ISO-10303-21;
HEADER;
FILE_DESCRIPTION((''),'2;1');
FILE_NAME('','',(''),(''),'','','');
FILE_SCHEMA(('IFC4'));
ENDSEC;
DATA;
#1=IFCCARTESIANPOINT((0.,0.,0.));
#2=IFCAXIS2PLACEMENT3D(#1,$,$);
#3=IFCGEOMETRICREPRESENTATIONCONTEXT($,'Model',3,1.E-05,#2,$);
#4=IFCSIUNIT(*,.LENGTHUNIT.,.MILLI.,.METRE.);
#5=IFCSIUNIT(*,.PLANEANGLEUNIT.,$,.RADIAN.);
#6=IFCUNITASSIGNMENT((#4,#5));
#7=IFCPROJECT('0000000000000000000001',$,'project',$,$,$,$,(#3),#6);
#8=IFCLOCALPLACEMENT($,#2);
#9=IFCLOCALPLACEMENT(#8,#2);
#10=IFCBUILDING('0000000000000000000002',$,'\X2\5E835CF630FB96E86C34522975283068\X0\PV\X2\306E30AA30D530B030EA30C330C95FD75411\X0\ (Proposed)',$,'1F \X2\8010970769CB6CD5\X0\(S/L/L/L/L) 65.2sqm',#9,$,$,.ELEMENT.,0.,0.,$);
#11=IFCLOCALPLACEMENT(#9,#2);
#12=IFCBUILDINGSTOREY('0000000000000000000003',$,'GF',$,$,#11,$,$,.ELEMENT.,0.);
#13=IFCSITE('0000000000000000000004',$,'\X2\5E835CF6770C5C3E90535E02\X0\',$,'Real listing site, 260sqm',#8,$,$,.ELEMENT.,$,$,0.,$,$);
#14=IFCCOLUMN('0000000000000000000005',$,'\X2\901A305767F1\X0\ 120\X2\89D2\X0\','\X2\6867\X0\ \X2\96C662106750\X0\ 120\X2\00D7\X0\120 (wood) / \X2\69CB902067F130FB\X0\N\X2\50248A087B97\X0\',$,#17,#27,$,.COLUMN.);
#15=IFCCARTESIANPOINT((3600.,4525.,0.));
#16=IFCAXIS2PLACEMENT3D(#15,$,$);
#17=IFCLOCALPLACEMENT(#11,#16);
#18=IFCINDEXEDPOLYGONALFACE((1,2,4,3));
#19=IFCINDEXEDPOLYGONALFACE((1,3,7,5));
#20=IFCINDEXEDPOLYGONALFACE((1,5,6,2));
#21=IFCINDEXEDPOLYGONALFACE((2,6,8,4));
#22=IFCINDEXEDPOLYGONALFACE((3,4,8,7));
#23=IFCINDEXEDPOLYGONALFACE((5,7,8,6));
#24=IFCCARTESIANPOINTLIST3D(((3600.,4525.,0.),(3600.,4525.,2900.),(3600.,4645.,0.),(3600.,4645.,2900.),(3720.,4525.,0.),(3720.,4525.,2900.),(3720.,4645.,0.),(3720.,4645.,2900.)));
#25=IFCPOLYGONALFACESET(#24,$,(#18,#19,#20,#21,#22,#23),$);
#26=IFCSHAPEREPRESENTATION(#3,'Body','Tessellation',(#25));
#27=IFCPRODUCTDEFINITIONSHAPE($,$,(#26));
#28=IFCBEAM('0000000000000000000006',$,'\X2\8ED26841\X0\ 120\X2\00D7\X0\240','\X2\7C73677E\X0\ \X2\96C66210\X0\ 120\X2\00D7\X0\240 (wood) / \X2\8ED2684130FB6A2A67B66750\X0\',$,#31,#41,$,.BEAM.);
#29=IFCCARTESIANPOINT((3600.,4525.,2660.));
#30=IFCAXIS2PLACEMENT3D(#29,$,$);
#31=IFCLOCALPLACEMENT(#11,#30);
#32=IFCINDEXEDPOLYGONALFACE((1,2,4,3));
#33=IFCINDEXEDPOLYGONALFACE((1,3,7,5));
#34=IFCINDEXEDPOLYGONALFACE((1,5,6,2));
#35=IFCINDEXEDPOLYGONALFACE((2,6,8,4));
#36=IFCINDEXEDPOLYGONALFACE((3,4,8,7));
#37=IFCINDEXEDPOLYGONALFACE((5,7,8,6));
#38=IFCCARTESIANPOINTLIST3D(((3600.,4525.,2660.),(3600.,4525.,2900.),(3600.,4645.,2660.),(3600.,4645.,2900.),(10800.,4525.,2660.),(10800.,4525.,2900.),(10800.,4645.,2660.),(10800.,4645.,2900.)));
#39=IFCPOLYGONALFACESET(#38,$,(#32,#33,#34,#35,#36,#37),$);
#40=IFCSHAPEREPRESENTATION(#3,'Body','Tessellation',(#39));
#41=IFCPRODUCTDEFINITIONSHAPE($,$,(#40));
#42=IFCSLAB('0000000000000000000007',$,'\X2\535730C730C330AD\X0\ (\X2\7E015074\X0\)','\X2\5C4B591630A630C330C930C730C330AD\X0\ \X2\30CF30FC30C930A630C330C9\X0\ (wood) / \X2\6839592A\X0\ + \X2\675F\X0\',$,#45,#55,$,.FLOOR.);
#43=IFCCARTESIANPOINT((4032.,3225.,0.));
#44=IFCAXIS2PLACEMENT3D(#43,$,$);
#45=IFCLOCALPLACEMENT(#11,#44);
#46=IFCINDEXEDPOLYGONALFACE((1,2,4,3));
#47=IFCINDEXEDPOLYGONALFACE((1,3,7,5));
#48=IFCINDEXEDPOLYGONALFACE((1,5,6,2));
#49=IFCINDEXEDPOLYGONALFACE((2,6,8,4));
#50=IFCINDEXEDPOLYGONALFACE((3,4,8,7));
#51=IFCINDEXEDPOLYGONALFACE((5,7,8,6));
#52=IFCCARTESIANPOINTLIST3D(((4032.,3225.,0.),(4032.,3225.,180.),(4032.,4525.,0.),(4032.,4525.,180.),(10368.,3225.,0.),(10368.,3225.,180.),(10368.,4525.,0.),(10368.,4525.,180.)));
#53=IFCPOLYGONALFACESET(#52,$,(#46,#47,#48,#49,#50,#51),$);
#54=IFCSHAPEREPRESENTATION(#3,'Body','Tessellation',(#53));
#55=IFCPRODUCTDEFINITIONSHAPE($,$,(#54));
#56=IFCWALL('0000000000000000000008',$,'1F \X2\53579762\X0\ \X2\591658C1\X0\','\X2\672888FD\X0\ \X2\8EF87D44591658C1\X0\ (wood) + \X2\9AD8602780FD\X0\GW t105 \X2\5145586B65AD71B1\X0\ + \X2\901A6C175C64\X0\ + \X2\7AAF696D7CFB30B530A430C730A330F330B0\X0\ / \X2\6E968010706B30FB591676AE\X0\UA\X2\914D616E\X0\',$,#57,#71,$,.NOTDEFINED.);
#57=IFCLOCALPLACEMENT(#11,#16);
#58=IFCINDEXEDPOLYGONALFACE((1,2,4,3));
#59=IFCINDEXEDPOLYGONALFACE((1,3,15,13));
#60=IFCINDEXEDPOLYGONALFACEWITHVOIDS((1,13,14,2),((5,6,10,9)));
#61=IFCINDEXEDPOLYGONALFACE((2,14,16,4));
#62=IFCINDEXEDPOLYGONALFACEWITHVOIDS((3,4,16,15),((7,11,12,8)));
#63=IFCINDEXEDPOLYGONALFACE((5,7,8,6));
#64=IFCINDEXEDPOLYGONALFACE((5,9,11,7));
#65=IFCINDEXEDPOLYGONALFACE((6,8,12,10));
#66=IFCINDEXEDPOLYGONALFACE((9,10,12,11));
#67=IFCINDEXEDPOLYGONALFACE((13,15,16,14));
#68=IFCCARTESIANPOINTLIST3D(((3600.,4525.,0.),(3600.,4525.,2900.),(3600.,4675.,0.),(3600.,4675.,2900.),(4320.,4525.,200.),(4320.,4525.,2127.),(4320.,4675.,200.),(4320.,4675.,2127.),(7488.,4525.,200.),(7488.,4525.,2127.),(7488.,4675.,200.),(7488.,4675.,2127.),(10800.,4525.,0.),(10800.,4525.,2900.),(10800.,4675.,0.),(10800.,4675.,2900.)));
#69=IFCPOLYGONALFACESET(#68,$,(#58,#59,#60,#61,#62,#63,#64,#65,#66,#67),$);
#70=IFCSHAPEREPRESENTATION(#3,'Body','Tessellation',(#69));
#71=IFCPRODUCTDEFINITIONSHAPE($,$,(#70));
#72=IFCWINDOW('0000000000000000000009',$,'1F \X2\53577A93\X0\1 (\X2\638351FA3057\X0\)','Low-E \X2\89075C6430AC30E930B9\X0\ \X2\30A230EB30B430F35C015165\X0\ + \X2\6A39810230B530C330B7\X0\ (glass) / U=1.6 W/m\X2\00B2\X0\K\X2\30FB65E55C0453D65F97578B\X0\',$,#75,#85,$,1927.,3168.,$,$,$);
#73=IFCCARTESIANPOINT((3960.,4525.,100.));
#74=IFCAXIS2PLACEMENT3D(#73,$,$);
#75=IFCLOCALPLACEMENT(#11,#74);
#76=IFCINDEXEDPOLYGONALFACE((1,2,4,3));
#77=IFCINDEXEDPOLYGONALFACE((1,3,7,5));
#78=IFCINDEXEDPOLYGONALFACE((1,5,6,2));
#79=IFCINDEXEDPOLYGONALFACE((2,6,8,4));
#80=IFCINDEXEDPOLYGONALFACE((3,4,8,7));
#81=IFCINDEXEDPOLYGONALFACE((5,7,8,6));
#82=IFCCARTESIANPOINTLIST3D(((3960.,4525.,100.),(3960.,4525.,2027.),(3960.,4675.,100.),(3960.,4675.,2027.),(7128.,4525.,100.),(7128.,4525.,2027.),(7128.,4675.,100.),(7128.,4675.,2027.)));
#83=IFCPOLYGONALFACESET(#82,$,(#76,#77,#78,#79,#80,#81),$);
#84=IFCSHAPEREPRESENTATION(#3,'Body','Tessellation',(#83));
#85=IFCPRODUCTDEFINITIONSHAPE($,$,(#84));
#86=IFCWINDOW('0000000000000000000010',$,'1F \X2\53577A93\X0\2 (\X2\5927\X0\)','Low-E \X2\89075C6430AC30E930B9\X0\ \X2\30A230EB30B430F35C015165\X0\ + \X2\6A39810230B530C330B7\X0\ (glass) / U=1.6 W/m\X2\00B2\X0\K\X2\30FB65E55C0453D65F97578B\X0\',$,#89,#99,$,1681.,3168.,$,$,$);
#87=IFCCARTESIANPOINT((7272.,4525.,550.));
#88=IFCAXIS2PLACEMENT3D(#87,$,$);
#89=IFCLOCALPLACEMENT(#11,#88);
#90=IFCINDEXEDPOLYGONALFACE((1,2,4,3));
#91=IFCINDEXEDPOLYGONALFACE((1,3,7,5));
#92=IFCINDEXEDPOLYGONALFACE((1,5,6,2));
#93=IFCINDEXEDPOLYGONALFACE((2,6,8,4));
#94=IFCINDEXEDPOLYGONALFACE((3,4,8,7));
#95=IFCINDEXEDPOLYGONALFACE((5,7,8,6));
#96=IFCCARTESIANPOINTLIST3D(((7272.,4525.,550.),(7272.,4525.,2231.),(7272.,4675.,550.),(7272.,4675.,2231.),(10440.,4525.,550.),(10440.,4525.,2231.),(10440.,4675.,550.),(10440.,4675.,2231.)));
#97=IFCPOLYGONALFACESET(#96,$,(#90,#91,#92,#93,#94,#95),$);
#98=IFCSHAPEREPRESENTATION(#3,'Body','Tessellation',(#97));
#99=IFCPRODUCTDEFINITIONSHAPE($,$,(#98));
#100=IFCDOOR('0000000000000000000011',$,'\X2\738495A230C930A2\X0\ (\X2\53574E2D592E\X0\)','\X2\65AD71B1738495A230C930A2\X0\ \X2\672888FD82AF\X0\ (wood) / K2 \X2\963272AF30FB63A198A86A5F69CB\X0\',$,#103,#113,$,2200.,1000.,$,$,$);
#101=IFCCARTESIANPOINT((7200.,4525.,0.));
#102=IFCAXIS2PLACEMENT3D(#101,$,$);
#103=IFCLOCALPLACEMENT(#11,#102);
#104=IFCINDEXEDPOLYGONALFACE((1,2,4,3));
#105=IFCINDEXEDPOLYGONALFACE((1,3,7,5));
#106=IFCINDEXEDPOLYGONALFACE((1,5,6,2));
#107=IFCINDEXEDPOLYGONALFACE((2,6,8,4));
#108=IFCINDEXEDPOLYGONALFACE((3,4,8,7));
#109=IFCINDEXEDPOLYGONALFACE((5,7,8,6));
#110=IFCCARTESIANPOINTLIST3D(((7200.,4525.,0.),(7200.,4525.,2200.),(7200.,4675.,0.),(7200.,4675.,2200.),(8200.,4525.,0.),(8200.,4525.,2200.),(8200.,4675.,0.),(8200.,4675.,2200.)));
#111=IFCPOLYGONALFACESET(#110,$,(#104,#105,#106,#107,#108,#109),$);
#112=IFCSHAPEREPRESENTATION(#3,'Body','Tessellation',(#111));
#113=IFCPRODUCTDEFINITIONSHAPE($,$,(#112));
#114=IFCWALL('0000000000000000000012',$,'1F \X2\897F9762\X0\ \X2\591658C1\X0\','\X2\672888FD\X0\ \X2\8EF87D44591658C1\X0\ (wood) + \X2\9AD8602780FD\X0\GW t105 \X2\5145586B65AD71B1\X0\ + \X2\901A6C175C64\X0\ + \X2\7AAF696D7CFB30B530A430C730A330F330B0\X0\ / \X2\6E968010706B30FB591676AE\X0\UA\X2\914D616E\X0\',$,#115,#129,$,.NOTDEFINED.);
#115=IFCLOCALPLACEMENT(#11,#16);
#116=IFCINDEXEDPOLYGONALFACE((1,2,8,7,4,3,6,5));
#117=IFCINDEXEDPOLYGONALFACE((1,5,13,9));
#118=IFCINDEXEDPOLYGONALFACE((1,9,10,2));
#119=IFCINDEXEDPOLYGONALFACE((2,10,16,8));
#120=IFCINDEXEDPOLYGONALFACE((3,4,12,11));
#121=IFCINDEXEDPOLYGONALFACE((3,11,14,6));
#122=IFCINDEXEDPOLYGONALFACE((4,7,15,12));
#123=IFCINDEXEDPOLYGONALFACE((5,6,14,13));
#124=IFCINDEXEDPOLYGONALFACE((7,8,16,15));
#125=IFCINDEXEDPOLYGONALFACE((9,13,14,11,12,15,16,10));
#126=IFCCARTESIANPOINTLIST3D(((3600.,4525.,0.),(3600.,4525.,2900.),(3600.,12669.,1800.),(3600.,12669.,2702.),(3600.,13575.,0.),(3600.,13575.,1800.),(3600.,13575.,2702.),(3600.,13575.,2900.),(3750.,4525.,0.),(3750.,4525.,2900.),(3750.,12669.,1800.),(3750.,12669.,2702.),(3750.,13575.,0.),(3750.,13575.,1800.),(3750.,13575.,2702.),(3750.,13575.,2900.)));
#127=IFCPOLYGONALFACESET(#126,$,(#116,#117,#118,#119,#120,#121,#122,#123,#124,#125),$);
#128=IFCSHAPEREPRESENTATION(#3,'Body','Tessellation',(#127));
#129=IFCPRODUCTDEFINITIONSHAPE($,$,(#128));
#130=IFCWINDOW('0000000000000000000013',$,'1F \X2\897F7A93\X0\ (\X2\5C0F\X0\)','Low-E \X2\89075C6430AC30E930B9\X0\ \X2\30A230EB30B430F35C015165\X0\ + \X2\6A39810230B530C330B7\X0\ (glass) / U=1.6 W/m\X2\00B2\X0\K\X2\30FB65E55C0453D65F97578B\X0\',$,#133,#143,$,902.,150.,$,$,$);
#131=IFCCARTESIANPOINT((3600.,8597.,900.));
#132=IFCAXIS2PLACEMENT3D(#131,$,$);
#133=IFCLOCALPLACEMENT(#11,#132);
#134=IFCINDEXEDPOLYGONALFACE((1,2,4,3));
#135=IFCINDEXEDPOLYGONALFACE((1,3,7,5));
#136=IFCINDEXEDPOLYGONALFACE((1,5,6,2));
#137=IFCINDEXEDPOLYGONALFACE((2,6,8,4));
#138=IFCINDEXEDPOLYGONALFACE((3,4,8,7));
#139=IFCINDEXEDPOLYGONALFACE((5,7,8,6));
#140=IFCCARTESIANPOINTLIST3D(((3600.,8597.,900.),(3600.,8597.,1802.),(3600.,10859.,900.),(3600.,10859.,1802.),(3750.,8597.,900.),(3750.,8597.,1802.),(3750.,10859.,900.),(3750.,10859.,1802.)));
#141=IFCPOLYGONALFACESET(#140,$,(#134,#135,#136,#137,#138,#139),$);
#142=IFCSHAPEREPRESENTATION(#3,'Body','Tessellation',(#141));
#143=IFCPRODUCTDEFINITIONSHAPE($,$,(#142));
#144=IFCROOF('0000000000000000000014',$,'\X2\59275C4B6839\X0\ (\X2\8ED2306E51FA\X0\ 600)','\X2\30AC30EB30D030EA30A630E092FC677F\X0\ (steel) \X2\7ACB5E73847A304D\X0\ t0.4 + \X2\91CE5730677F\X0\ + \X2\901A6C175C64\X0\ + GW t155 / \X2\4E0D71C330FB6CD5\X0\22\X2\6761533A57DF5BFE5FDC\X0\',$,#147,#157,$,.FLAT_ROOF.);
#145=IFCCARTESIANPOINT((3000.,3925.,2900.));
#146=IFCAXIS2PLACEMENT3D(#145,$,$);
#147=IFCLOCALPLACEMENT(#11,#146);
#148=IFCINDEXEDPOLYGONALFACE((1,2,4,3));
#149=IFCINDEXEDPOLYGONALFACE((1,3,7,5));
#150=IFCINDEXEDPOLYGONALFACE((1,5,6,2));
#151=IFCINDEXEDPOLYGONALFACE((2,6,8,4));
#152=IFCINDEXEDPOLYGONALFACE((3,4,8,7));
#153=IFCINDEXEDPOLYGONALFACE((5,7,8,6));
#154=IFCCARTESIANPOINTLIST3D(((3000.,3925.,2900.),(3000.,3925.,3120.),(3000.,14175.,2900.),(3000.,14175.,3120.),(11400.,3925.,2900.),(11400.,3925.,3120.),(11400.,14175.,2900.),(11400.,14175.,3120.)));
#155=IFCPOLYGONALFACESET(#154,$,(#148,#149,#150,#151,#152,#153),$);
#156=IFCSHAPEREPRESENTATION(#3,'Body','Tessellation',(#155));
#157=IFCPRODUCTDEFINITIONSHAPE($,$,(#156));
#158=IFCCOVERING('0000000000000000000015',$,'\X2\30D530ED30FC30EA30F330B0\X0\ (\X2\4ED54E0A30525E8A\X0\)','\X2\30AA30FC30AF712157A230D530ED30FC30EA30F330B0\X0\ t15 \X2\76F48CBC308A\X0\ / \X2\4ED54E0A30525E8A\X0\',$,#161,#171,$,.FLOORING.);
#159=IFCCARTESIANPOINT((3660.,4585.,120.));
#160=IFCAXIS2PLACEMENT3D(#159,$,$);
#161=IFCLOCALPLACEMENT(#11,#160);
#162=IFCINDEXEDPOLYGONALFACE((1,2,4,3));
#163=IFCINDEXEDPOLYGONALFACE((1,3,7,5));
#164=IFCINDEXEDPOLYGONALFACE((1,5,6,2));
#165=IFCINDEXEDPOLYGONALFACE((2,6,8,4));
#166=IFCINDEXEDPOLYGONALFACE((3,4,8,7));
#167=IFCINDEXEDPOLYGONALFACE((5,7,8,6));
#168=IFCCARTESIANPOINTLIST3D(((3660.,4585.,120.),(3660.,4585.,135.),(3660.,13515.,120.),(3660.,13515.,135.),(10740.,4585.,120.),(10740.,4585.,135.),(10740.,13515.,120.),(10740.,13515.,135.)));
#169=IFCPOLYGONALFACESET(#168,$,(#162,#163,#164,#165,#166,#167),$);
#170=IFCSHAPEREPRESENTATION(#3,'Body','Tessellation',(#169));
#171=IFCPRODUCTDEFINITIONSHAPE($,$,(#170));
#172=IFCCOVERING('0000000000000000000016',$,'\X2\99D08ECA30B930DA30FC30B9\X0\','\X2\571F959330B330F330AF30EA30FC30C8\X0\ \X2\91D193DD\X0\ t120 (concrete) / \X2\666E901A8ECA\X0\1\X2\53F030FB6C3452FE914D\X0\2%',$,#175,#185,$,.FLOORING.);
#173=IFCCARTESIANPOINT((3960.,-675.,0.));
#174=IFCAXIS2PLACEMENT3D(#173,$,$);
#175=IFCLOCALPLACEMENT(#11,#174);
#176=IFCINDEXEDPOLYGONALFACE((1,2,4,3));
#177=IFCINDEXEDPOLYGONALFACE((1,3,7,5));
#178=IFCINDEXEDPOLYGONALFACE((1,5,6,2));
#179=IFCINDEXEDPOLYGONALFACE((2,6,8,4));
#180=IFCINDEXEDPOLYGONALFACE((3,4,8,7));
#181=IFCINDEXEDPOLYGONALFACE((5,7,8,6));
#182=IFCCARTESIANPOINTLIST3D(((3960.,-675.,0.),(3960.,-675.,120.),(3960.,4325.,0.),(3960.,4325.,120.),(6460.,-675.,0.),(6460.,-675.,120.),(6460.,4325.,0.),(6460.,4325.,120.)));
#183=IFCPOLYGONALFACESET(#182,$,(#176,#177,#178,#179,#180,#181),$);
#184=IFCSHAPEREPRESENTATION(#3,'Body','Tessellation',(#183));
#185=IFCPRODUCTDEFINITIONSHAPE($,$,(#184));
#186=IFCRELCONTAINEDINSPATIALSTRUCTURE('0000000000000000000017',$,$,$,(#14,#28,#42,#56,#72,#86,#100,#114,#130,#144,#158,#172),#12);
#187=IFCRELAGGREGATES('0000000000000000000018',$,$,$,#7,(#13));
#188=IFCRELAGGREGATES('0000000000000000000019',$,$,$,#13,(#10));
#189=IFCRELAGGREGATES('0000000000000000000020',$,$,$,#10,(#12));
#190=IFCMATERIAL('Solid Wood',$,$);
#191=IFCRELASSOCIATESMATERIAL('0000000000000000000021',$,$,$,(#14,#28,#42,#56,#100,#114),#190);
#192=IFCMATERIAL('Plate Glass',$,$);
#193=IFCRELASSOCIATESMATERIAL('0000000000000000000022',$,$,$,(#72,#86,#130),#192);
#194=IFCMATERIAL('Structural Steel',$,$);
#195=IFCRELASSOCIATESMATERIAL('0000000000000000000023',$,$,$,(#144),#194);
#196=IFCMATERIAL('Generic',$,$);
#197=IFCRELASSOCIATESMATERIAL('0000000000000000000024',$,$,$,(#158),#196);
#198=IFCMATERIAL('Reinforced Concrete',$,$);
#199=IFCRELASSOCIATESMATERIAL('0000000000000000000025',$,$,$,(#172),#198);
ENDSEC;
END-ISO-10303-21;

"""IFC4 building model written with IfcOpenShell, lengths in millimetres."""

from ifc_helpers import new_model, si_unit, frame, frame_2d, origin, place, context, project, spatial, rectangle, extrude, material, element, fill, save


model = new_model("IFC4")

# Units and contexts
model_context = context("Model", 3, precision=1e-05, world=origin())
ifc_project = project(units=[si_unit("LENGTHUNIT", "METRE", prefix="MILLI"), si_unit("PLANEANGLEUNIT", "RADIAN")], contexts=[model_context])

# Site, building, storey
site_placement = place(None, origin())
site = spatial("IfcSite", under=ifc_project, at=site_placement, Name="広島県尾道市", ObjectType="Real listing site, 260sqm", CompositionType="ELEMENT", RefElevation=0.0)
building_placement = place(site_placement, origin())
building = spatial("IfcBuilding", under=site, at=building_placement, Name="広島・雨水利用とPVのオフグリッド志向 (Proposed)", ObjectType="1F 耐震構法(S/L/L/L/L) 65.2sqm", CompositionType="ELEMENT", ElevationOfRefHeight=0.0, ElevationOfTerrain=0.0)
storey_placement = place(building_placement, origin())
storey = spatial("IfcBuildingStorey", under=building, at=storey_placement, Name="GF", CompositionType="ELEMENT", Elevation=0.0)

# Column
ifc_material_1 = material(Name="Solid Wood")
column_placement = place(storey_placement, frame((3600.0, 4525.0, 0.0)))
element("IfcColumn", 1, at=column_placement, inside=storey, material=ifc_material_1, Name="通し柱 120角", Description="桧 集成材 120×120 (wood) / 構造柱・N値計算", PredefinedType="COLUMN", context=model_context, shape_type="SweptSolid", body=[
    extrude(rectangle(XDim=120.0, YDim=120.0, at=frame_2d((60.0, 60.0))), frame((3600.0, 4525.0, 0.0)), (0.0, 0.0, 1.0), 2900.0),
])

# Beam
beam_1_placement = place(storey_placement, frame((3600.0, 4525.0, 2660.0)))
element("IfcBeam", 2, at=beam_1_placement, inside=storey, material=ifc_material_1, Name="軒桁 120×240", Description="米松 集成 120×240 (wood) / 軒桁・横架材", PredefinedType="BEAM", context=model_context, shape_type="SweptSolid", body=[
    extrude(rectangle(XDim=7200.0, YDim=120.0, at=frame_2d((3600.0, 60.0))), frame((3600.0, 4525.0, 2660.0)), (0.0, 0.0, 1.0), 240.0),
])

# Slab
ifc_material_2 = material(Name="Reinforced Concrete")
slab_1_placement = place(storey_placement, frame((4032.0, 3225.0, 0.0)))
element("IfcSlab", 3, at=slab_1_placement, inside=storey, material=ifc_material_1, Name="南デッキ (縁側)", Description="屋外ウッドデッキ ハードウッド (wood) / 根太 + 束", PredefinedType="FLOOR", context=model_context, shape_type="SweptSolid", body=[
    extrude(rectangle(XDim=6336.0, YDim=1300.0, at=frame_2d((3168.0, 650.0))), frame((4032.0, 3225.0, 0.0)), (0.0, 0.0, 1.0), 180.0),
])

# Wall, openings, windows, door
wall_1_placement = place(storey_placement, frame((3600.0, 4525.0, 0.0)))
wall_1 = element("IfcWall", 4, at=wall_1_placement, inside=storey, material=ifc_material_1, Name="1F 南面 外壁", Description="木製 軸組外壁 (wood) + 高性能GW t105 充填断熱 + 通気層 + 窯業系サイディング / 準耐火・外皮UA配慮", PredefinedType="NOTDEFINED", context=model_context, shape_type="SweptSolid", body=[
    extrude(rectangle(XDim=7200.0, YDim=150.0, at=frame_2d((3600.0, 75.0))), frame((3600.0, 4525.0, 0.0)), (0.0, 0.0, 1.0), 2900.0),
])
opening_1_placement = place(storey_placement, frame((3960.0, 4525.0, 100.0)))
opening_1 = element("IfcOpeningElement", 5, at=opening_1_placement, cuts=wall_1, PredefinedType="NOTDEFINED", context=model_context, shape_type="SweptSolid", body=[
    extrude(rectangle(XDim=3168.0, YDim=150.0, at=frame_2d((1584.0, 75.0))), frame((3960.0, 4525.0, 100.0)), (0.0, 0.0, 1.0), 1927.0),
])
opening_2_placement = place(storey_placement, frame((7272.0, 4525.0, 550.0)))
opening_2 = element("IfcOpeningElement", 6, at=opening_2_placement, cuts=wall_1, PredefinedType="NOTDEFINED", context=model_context, shape_type="SweptSolid", body=[
    extrude(rectangle(XDim=3168.0, YDim=150.0, at=frame_2d((1584.0, 75.0))), frame((7272.0, 4525.0, 550.0)), (0.0, 0.0, 1.0), 1681.0),
])
opening_3_placement = place(storey_placement, frame((7200.0, 4525.0, 0.0)))
opening_3 = element("IfcOpeningElement", 7, at=opening_3_placement, cuts=wall_1, PredefinedType="NOTDEFINED", context=model_context, shape_type="SweptSolid", body=[
    extrude(rectangle(XDim=1000.0, YDim=150.0, at=frame_2d((500.0, 75.0))), frame((7200.0, 4525.0, 0.0)), (0.0, 0.0, 1.0), 2200.0),
])
ifc_material_3 = material(Name="Plate Glass")
window_1_placement = place(storey_placement, frame((3960.0, 4525.0, 100.0)))
window_1 = element("IfcWindow", 8, at=window_1_placement, inside=storey, material=ifc_material_3, Name="1F 南窓1 (掃出し)", Description="Low-E 複層ガラス アルゴン封入 + 樹脂サッシ (glass) / U=1.6 W/m²K・日射取得型", OverallHeight=1927.0, OverallWidth=3168.0, context=model_context, shape_type="SweptSolid", body=[
    extrude(rectangle(XDim=3168.0, YDim=150.0, at=frame_2d((1584.0, 75.0))), frame((3960.0, 4525.0, 100.0)), (0.0, 0.0, 1.0), 1927.0),
])
fill(opening_1, window_1)
window_2_placement = place(storey_placement, frame((7272.0, 4525.0, 550.0)))
window_2 = element("IfcWindow", 9, at=window_2_placement, inside=storey, material=ifc_material_3, Name="1F 南窓2 (大)", Description="Low-E 複層ガラス アルゴン封入 + 樹脂サッシ (glass) / U=1.6 W/m²K・日射取得型", OverallHeight=1681.0, OverallWidth=3168.0, context=model_context, shape_type="SweptSolid", body=[
    extrude(rectangle(XDim=3168.0, YDim=150.0, at=frame_2d((1584.0, 75.0))), frame((7272.0, 4525.0, 550.0)), (0.0, 0.0, 1.0), 1681.0),
])
fill(opening_2, window_2)
door_placement = place(storey_placement, frame((7200.0, 4525.0, 0.0)))
door = element("IfcDoor", 10, at=door_placement, inside=storey, material=ifc_material_1, Name="玄関ドア (南中央)", Description="断熱玄関ドア 木製芯 (wood) / K2 防犯・採風機構", OverallHeight=2200.0, OverallWidth=1000.0, context=model_context, shape_type="SweptSolid", body=[
    extrude(rectangle(XDim=1000.0, YDim=150.0, at=frame_2d((500.0, 75.0))), frame((7200.0, 4525.0, 0.0)), (0.0, 0.0, 1.0), 2200.0),
])
fill(opening_3, door)

# Wall, opening, window
wall_2_placement = place(storey_placement, frame((3600.0, 4525.0, 0.0)))
wall_2 = element("IfcWall", 11, at=wall_2_placement, inside=storey, material=ifc_material_1, Name="1F 西面 外壁", Description="木製 軸組外壁 (wood) + 高性能GW t105 充填断熱 + 通気層 + 窯業系サイディング / 準耐火・外皮UA配慮", PredefinedType="NOTDEFINED", context=model_context, shape_type="SweptSolid", body=[
    extrude(rectangle(XDim=150.0, YDim=9050.0, at=frame_2d((75.0, 4525.0))), frame((3600.0, 4525.0, 0.0)), (0.0, 0.0, 1.0), 2900.0),
])
opening_4_placement = place(storey_placement, frame((3600.0, 8597.0, 900.0)))
opening_4 = element("IfcOpeningElement", 12, at=opening_4_placement, cuts=wall_2, PredefinedType="NOTDEFINED", context=model_context, shape_type="SweptSolid", body=[
    extrude(rectangle(XDim=150.0, YDim=2262.0, at=frame_2d((75.0, 1131.0))), frame((3600.0, 8597.0, 900.0)), (0.0, 0.0, 1.0), 902.0),
])
window_3_placement = place(storey_placement, frame((3600.0, 8597.0, 900.0)))
window_3 = element("IfcWindow", 13, at=window_3_placement, inside=storey, material=ifc_material_3, Name="1F 西窓 (小)", Description="Low-E 複層ガラス アルゴン封入 + 樹脂サッシ (glass) / U=1.6 W/m²K・日射取得型", OverallHeight=902.0, OverallWidth=150.0, context=model_context, shape_type="SweptSolid", body=[
    extrude(rectangle(XDim=150.0, YDim=2262.0, at=frame_2d((75.0, 1131.0))), frame((3600.0, 8597.0, 900.0)), (0.0, 0.0, 1.0), 902.0),
])
fill(opening_4, window_3)

# Roof
ifc_material_4 = material(Name="Structural Steel")
roof_placement = place(storey_placement, frame((3000.0, 3925.0, 2900.0)))
element("IfcRoof", 14, at=roof_placement, inside=storey, material=ifc_material_4, Name="大屋根 (軒の出 600)", Description="ガルバリウム鋼板 (steel) 立平葺き t0.4 + 野地板 + 通気層 + GW t155 / 不燃・法22条区域対応", PredefinedType="FLAT_ROOF", context=model_context, shape_type="SweptSolid", body=[
    extrude(rectangle(XDim=8400.0, YDim=10250.0, at=frame_2d((4200.0, 5125.0))), frame((3000.0, 3925.0, 2900.0)), (0.0, 0.0, 1.0), 220.0),
])

# Coverings
ifc_material_5 = material(Name="Generic")
covering_1_placement = place(storey_placement, frame((3660.0, 4585.0, 120.0)))
element("IfcCovering", 15, at=covering_1_placement, inside=storey, material=ifc_material_5, Name="フローリング (仕上げ床)", Description="オーク無垢フローリング t15 直貼り / 仕上げ床", PredefinedType="FLOORING", context=model_context, shape_type="SweptSolid", body=[
    extrude(rectangle(XDim=7080.0, YDim=8930.0, at=frame_2d((3540.0, 4465.0))), frame((3660.0, 4585.0, 120.0)), (0.0, 0.0, 1.0), 15.0),
])
covering_2_placement = place(storey_placement, frame((3960.0, -675.0, 0.0)))
element("IfcCovering", 16, at=covering_2_placement, inside=storey, material=ifc_material_2, Name="駐車スペース", Description="土間コンクリート 金鏝 t120 (concrete) / 普通車1台・水勾配2%", PredefinedType="FLOORING", context=model_context, shape_type="SweptSolid", body=[
    extrude(rectangle(XDim=2500.0, YDim=5000.0, at=frame_2d((1250.0, 2500.0))), frame((3960.0, -675.0, 0.0)), (0.0, 0.0, 1.0), 120.0),
])

save(model, "model.ifc")
